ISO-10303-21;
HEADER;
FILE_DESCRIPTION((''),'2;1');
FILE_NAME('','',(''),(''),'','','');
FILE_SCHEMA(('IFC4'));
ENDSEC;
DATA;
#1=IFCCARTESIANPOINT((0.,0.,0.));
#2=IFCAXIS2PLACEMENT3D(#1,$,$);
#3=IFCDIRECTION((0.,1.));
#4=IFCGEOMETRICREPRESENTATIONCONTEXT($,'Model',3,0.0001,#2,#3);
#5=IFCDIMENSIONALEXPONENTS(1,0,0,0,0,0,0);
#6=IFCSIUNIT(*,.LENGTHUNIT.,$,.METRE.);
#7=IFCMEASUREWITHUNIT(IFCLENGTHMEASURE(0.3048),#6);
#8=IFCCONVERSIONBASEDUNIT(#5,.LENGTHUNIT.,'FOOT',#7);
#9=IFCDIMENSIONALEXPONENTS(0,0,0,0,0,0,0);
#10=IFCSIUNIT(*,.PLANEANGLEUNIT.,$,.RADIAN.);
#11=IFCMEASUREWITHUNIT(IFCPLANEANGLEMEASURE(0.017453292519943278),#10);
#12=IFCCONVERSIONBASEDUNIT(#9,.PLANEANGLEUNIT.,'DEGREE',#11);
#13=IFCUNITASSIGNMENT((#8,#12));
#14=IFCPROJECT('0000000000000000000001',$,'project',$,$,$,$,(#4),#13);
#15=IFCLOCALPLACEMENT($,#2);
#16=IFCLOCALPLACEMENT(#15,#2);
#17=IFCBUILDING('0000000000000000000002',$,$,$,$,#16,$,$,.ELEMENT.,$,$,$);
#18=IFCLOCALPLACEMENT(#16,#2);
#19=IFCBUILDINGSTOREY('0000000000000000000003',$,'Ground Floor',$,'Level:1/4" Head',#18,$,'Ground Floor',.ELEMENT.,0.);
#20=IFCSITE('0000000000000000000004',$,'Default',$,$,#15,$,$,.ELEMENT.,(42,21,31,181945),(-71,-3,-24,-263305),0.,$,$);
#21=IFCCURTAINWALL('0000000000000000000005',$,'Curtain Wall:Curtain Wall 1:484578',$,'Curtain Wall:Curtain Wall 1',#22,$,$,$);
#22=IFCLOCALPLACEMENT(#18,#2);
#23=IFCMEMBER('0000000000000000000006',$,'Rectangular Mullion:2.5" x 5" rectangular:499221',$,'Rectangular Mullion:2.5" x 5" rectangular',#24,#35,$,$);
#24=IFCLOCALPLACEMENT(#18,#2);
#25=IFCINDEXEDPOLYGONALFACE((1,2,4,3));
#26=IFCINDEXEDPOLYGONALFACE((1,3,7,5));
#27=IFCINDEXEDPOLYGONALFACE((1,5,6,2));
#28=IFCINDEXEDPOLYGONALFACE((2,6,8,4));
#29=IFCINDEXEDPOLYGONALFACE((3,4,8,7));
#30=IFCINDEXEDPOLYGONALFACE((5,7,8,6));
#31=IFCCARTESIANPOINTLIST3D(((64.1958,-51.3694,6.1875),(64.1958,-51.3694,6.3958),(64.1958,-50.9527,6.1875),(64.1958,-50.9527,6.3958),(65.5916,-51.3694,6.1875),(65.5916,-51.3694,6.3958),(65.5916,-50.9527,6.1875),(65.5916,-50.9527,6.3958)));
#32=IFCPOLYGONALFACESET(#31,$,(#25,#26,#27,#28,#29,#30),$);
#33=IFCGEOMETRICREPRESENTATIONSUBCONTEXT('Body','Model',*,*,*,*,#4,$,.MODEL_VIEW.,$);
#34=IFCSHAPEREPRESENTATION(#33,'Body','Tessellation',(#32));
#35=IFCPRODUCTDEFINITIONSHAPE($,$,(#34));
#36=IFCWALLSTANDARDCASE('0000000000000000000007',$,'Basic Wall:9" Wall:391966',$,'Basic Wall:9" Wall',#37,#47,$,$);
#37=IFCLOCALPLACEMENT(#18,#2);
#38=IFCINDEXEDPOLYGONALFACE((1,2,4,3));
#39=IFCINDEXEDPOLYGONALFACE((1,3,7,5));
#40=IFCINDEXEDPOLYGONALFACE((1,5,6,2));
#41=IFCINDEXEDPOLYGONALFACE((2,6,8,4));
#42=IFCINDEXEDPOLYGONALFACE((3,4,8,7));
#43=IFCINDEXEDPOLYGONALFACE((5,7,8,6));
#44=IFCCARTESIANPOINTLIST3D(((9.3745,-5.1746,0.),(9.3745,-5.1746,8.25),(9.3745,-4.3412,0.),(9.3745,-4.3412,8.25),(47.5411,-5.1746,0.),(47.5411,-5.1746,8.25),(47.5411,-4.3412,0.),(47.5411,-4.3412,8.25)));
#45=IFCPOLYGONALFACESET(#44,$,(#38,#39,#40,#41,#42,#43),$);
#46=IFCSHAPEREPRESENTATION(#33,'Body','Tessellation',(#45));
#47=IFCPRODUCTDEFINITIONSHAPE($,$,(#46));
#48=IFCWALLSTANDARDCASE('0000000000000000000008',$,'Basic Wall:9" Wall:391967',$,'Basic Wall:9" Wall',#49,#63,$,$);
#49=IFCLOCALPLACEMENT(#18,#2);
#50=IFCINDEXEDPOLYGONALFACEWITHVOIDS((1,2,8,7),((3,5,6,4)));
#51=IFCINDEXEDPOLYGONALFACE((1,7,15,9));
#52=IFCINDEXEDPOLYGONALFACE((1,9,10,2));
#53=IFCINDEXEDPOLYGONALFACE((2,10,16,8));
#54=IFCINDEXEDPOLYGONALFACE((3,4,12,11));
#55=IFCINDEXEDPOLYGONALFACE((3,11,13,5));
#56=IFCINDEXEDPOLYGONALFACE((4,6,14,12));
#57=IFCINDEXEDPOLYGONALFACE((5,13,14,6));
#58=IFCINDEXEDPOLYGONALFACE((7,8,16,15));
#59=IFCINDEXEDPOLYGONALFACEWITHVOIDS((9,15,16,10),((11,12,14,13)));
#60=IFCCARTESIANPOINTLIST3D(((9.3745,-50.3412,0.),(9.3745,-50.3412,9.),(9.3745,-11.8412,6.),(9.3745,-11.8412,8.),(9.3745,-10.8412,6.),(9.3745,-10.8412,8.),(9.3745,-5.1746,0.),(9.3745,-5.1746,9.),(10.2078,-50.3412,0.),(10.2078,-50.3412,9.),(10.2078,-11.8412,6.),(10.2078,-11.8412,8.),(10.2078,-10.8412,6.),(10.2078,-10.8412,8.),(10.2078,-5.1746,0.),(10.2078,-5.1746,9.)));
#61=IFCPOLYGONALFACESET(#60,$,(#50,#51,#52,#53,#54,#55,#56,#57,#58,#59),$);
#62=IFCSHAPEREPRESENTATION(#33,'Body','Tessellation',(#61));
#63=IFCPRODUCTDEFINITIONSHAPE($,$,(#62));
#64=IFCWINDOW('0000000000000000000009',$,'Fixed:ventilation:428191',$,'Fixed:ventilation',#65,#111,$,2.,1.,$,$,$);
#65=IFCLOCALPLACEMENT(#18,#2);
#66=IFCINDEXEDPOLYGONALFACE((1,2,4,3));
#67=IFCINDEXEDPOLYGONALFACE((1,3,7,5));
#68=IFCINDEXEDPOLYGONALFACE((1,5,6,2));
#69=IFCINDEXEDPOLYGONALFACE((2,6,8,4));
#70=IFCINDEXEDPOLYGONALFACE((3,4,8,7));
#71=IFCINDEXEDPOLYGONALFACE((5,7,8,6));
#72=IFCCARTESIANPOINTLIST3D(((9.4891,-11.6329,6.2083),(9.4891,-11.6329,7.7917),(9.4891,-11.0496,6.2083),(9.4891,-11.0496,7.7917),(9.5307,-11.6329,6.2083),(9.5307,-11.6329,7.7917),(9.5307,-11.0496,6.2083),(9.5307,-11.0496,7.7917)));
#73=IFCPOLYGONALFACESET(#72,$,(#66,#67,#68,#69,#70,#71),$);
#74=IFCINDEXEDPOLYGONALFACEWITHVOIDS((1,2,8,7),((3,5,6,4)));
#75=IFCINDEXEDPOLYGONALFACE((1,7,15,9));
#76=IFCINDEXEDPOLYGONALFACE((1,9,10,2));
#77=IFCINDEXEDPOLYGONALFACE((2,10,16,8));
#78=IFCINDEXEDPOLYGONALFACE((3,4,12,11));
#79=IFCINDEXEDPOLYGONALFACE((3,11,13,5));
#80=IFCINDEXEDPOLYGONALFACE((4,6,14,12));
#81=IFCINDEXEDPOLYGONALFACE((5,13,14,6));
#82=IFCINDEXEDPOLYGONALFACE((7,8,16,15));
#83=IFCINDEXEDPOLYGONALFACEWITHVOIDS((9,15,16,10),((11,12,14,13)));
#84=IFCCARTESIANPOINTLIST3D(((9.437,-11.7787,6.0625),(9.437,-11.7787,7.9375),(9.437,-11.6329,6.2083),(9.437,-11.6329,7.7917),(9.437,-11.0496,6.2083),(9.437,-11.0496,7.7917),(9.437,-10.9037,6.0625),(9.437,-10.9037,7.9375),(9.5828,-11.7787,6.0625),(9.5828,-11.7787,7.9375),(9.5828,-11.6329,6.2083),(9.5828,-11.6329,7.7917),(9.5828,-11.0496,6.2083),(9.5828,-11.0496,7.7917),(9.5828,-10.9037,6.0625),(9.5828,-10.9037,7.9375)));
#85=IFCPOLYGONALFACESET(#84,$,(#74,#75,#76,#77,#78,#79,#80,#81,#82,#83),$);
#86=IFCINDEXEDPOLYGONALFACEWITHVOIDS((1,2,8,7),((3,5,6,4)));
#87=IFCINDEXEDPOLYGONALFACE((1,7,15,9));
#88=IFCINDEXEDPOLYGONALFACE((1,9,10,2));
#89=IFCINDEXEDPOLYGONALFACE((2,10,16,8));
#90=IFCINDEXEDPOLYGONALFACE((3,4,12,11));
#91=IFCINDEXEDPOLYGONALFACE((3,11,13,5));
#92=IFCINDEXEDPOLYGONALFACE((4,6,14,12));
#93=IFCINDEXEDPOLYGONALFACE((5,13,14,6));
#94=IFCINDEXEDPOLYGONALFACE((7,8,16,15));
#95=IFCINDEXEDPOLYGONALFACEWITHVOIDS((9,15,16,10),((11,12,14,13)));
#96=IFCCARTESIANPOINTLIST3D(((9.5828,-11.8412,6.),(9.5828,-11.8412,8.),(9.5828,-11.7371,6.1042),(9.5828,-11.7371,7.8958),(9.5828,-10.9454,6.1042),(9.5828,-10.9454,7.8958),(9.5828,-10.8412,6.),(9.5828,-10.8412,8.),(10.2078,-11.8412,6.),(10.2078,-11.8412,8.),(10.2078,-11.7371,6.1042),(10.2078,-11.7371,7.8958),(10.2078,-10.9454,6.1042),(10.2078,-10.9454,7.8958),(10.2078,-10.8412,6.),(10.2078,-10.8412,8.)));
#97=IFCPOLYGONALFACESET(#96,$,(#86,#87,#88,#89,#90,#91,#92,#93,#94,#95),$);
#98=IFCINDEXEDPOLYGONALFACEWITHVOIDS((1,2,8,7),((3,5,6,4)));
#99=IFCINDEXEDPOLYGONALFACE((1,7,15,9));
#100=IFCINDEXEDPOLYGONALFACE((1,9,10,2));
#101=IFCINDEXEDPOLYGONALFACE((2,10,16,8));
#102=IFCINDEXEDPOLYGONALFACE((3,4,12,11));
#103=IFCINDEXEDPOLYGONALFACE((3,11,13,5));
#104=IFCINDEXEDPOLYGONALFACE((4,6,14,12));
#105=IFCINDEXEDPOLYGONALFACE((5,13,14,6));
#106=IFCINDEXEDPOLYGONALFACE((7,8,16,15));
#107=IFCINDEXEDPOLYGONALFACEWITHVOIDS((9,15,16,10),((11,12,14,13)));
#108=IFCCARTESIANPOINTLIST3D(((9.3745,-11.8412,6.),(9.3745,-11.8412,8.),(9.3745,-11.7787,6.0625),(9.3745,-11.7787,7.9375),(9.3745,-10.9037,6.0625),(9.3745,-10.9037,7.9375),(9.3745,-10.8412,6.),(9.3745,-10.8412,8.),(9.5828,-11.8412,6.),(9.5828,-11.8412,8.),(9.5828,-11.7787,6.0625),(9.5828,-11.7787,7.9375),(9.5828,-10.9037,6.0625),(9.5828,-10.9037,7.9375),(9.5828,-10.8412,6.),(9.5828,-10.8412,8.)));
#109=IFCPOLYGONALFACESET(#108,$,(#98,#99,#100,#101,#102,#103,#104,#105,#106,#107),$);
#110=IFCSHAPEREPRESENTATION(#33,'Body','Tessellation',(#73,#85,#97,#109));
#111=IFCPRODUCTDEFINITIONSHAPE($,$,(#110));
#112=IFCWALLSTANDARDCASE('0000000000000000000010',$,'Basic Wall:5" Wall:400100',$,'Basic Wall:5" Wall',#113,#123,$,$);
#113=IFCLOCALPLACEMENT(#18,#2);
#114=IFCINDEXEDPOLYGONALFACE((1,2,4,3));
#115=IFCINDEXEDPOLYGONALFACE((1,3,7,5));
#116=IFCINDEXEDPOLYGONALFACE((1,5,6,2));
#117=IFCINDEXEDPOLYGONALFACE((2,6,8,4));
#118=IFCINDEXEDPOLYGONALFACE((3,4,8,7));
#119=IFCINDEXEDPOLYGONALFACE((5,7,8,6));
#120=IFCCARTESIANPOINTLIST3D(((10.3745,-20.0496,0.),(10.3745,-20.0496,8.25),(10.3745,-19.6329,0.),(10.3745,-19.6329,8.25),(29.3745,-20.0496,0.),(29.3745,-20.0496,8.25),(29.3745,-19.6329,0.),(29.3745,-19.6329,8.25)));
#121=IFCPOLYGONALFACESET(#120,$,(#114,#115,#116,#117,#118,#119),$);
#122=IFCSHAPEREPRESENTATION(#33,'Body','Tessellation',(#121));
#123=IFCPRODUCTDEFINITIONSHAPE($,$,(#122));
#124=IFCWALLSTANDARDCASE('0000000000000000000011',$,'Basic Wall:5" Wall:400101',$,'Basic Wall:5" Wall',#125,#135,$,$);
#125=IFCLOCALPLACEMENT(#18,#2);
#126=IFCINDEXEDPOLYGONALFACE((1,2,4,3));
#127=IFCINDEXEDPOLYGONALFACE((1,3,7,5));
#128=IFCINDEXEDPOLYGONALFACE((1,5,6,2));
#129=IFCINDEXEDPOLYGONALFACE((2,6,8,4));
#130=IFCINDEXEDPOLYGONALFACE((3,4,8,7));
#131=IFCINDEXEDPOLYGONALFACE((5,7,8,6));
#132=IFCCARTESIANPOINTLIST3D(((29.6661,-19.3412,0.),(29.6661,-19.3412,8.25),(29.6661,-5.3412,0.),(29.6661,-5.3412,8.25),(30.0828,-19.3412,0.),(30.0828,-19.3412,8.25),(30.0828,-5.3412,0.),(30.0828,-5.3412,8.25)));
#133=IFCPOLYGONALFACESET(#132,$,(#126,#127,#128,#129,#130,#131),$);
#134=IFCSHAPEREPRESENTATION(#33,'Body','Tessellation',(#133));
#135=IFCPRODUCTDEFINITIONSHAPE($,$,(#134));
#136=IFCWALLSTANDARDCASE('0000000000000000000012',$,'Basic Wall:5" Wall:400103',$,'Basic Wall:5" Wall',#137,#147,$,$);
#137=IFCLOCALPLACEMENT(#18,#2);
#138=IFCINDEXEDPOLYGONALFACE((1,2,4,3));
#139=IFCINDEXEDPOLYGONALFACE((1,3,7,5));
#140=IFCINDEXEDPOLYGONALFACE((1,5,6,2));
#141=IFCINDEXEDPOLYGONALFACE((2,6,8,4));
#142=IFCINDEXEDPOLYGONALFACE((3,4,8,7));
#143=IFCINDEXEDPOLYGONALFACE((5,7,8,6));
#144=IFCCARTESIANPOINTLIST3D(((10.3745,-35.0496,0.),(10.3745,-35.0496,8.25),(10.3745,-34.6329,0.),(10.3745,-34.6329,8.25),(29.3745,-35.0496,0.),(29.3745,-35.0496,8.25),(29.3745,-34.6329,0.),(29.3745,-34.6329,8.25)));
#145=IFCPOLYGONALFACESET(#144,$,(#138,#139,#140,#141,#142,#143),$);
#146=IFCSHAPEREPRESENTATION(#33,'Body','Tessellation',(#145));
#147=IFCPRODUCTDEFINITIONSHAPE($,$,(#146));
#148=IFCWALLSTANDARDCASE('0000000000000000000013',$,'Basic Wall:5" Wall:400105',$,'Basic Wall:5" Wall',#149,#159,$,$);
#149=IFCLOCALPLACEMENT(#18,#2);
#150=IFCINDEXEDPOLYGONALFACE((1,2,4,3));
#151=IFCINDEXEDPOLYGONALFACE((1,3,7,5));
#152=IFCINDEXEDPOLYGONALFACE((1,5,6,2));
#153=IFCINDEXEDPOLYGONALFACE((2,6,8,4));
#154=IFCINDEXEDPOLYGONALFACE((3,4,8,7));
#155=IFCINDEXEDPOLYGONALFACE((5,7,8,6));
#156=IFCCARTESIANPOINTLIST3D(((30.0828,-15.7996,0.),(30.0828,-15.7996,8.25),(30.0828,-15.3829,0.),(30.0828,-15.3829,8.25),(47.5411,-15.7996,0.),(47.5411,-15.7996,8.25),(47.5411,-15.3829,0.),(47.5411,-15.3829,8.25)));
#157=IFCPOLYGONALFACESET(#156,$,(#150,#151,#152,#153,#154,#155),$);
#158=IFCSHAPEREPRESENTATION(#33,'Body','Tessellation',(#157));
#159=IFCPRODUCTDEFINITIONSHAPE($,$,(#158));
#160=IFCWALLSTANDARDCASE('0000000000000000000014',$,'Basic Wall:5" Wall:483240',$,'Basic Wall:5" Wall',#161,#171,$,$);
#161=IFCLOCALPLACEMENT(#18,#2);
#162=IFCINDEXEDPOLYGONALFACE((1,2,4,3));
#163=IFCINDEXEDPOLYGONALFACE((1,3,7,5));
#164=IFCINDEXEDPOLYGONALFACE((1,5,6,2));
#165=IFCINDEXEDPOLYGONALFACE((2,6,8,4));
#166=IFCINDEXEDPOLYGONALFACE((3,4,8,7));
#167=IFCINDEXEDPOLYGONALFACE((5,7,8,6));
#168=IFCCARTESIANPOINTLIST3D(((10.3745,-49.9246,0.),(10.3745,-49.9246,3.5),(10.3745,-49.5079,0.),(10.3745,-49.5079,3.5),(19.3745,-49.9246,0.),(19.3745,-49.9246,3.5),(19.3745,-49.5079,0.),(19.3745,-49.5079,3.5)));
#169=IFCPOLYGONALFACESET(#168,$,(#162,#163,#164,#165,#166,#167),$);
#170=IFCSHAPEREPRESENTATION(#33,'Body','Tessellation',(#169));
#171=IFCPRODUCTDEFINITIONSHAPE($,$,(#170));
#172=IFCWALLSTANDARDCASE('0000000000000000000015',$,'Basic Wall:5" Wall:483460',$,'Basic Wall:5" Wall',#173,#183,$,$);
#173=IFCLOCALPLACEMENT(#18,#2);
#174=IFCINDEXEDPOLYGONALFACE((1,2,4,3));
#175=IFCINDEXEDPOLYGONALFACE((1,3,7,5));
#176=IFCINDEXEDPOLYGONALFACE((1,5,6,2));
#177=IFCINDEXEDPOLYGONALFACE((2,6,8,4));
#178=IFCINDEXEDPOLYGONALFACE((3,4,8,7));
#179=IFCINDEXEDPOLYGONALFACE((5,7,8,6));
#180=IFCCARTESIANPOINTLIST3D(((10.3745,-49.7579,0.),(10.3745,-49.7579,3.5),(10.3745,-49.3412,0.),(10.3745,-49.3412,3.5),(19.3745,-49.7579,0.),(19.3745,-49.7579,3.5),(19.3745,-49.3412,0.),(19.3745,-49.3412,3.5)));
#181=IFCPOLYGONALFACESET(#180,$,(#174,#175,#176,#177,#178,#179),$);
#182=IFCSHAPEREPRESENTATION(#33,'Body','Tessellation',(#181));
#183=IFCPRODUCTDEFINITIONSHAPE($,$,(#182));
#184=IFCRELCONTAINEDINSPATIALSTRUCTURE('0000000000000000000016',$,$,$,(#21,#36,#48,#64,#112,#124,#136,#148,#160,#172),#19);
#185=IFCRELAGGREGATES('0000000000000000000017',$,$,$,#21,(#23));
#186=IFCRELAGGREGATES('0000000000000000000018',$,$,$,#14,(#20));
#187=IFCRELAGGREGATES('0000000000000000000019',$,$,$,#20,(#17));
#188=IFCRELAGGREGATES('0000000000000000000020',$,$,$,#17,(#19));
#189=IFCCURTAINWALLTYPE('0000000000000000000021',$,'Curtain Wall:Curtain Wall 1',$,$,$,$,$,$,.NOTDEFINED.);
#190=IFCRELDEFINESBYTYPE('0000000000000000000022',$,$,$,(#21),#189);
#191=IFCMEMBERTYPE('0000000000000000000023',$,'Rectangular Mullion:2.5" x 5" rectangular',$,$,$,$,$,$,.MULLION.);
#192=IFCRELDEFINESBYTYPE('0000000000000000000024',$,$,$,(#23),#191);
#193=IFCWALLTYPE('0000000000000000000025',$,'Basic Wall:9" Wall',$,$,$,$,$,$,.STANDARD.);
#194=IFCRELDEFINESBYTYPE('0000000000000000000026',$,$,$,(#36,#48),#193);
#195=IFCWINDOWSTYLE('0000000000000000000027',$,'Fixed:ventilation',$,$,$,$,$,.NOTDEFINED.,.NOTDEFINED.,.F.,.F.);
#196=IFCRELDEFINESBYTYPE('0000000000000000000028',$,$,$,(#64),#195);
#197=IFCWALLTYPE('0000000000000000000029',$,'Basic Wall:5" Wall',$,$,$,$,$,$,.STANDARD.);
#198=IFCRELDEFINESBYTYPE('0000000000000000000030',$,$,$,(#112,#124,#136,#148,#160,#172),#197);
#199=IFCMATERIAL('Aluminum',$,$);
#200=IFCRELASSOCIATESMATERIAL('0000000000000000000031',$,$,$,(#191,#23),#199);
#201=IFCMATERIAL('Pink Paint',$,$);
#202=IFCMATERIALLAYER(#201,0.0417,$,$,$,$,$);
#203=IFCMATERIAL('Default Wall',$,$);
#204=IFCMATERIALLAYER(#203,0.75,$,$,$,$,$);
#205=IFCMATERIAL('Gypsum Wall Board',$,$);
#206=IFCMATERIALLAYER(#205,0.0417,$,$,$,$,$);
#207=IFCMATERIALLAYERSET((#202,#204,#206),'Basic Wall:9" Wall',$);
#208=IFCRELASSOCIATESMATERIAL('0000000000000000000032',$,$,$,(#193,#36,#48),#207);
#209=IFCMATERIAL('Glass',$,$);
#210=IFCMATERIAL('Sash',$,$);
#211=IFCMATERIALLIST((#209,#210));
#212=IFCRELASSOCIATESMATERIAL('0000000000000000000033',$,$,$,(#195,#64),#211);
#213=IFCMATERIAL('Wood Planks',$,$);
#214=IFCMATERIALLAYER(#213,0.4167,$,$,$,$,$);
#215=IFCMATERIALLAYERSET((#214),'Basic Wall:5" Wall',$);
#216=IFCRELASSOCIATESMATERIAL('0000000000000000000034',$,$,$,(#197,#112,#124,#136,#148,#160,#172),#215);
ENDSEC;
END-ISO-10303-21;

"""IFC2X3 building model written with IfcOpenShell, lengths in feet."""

from ifc_helpers import new_model, entity, si_unit, converted_unit, direction, frame, frame_2d, origin, origin_2d_with_axis, place, context, subcontext, project, spatial, polyline, rectangle, outline, extrude, source, transform, mapped, material, material_list, layer, layer_set, layer_usage, type_object, type_shapes, element, fill, aggregate, save


model = new_model("IFC2X3")

# Units and contexts
model_context = context("Model", 3, precision=0.0001, world=origin(), true_north=direction((0.0, 1.0)))
body_context = subcontext(model_context, "Body", "Model", "MODEL_VIEW")
ifc_project = project(units=[converted_unit("LENGTHUNIT", "FOOT", entity("IfcLengthMeasure", 0.3048), si_unit("LENGTHUNIT", "METRE"), dimensions=[1, 0, 0, 0, 0, 0, 0]), converted_unit("PLANEANGLEUNIT", "DEGREE", entity("IfcPlaneAngleMeasure", 0.017453292519943278), si_unit("PLANEANGLEUNIT", "RADIAN"), dimensions=[0, 0, 0, 0, 0, 0, 0])], contexts=[model_context])

# Site, building, storey
site_placement = place(None, origin())
site = spatial("IfcSite", under=ifc_project, at=site_placement, Name="Default", CompositionType="ELEMENT", RefLatitude=(42, 21, 31, 181945), RefLongitude=(-71, -3, -24, -263305), RefElevation=0.0)
building_placement = place(site_placement, origin())
building = spatial("IfcBuilding", under=site, at=building_placement, CompositionType="ELEMENT")
storey_placement = place(building_placement, origin())
storey = spatial("IfcBuildingStorey", under=building, at=storey_placement, Name="Ground Floor", ObjectType="Level:1/4\" Head", LongName="Ground Floor", CompositionType="ELEMENT", Elevation=0.0)

# Curtain wall, member
curtain_wall_type = type_object("IfcCurtainWallType", Name="Curtain Wall:Curtain Wall 1", PredefinedType="NOTDEFINED")
curtain_wall_placement = place(storey_placement, origin())
curtain_wall = element("IfcCurtainWall", 1, at=curtain_wall_placement, inside=storey, type_object=curtain_wall_type, Name="Curtain Wall:Curtain Wall 1:484578", ObjectType="Curtain Wall:Curtain Wall 1")
ifc_material_1 = material(Name="Aluminum")
member_type_1 = type_object("IfcMemberType", Name="Rectangular Mullion:2.5\" x 5\" rectangular", PredefinedType="MULLION", material=ifc_material_1)
shared_shape_1 = source(origin(), body_context, "Body", "SweptSolid", [
    extrude(rectangle(XDim=0.2083, YDim=0.4167, at=origin_2d_with_axis()), frame((0.0, 0.0, -1.3958), z_axis=(0.0, 0.0, 1.0), x_axis=(-1.0, 0.0, 0.0)), (0.0, 0.0, 1.0), 1.3958),
])
type_shapes(member_type_1, [shared_shape_1])
member_1_placement = place(curtain_wall_placement, frame((65.5916, -51.161, 6.2917), z_axis=(1.0, 0.0, 0.0), x_axis=(0.0, 0.0, 1.0)))
member_1 = element("IfcMember", 2, at=member_1_placement, type_object=member_type_1, material=ifc_material_1, Name="Rectangular Mullion:2.5\" x 5\" rectangular:499221", ObjectType="Rectangular Mullion:2.5\" x 5\" rectangular", context=body_context, shape_type="MappedRepresentation", body=[
    mapped(shared_shape_1, transform((0.0, 0.0, 0.0), scale=1.0)),
])

# Shared definitions
ifc_material_2 = material(Name="Glass")
aggregate(curtain_wall, [member_1])

# Wall
ifc_material_3 = material(Name="Pink Paint")
ifc_layer_1 = layer(ifc_material_3, 0.0417)
ifc_material_4 = material(Name="Default Wall")
ifc_layer_2 = layer(ifc_material_4, 0.75)
ifc_material_5 = material(Name="Gypsum Wall Board")
ifc_layer_3 = layer(ifc_material_5, 0.0417)
ifc_layer_set_1 = layer_set([ifc_layer_1, ifc_layer_2, ifc_layer_3], Name="Basic Wall:9\" Wall")
ifc_layer_usage_1 = layer_usage(ifc_layer_set_1, "AXIS2", "NEGATIVE", 0.4167)
wall_type_1 = type_object("IfcWallType", Name="Basic Wall:9\" Wall", PredefinedType="STANDARD", material=ifc_layer_set_1)
wall_1_placement = place(storey_placement, frame((9.3745, -4.7579, 0.0)))
element("IfcWallStandardCase", 3, at=wall_1_placement, inside=storey, type_object=wall_type_1, material=ifc_layer_usage_1, Name="Basic Wall:9\" Wall:391966", ObjectType="Basic Wall:9\" Wall", context=body_context, shape_type="SweptSolid", body=[
    extrude(rectangle(XDim=38.1667, YDim=0.8333, at=frame_2d((19.0833, 0.0), x_axis=(-1.0, 0.0))), origin(), (0.0, 0.0, 1.0), 8.25),
])

# Wall, opening, window
wall_2_placement = place(storey_placement, frame((9.7911, -50.3412, 0.0), z_axis=(0.0, 0.0, 1.0), x_axis=(0.0, 1.0, 0.0)))
wall_2 = element("IfcWallStandardCase", 4, at=wall_2_placement, inside=storey, type_object=wall_type_1, material=ifc_layer_usage_1, Name="Basic Wall:9\" Wall:391967", ObjectType="Basic Wall:9\" Wall", context=body_context, shape_type="SweptSolid", body=[
    extrude(rectangle(XDim=45.1667, YDim=0.8333, at=frame_2d((22.5833, 0.0), x_axis=(-1.0, 0.0))), origin(), (0.0, 0.0, 1.0), 9.0),
])
opening_1_placement = place(wall_2_placement, frame((38.5, -0.4167, 6.0)))
opening_1 = element("IfcOpeningElement", 5, at=opening_1_placement, cuts=wall_2, ObjectType="Opening", context=body_context, shape_type="SweptSolid", body=[
    extrude(rectangle(XDim=2.0, YDim=1.0, at=frame_2d((1.0, 0.5), x_axis=(-1.0, 0.0))), frame((0.0, 0.0, 0.0), z_axis=(0.0, 1.0, 0.0), x_axis=(0.0, 0.0, 1.0)), (0.0, 0.0, 1.0), 0.8333),
])
ifc_material_6 = material(Name="Sash")
ifc_material_list_1 = material_list([ifc_material_2, ifc_material_6])
window_style = type_object("IfcWindowStyle", Name="Fixed:ventilation", ConstructionType="NOTDEFINED", OperationType="NOTDEFINED", ParameterTakesPrecedence=False, Sizeable=False, material=ifc_material_list_1)
shared_shape_2 = source(origin(), body_context, "Body", "SweptSolid", [
    extrude(rectangle(XDim=0.0417, YDim=0.5833, at=origin_2d_with_axis()), frame((0.5, 0.6979, 0.2083), z_axis=(0.0, 0.0, 1.0), x_axis=(0.0, 1.0, 0.0)), (0.0, 0.0, 1.0), 1.5833),
    extrude(outline(polyline([(-0.4375, -0.9375), (0.4375, -0.9375), (0.4375, 0.9375), (-0.4375, 0.9375), (-0.4375, -0.9375)]), holes=[polyline([(-0.2917, -0.7917), (-0.2917, 0.7917), (0.2917, 0.7917), (0.2917, -0.7917), (-0.2917, -0.7917)])]), frame((0.5, 0.625, 1.0), z_axis=(0.0, 1.0, 0.0), x_axis=(1.0, 0.0, 0.0)), (0.0, 0.0, 1.0), 0.1458),
    extrude(outline(polyline([(-0.5, -1.0), (0.5, -1.0), (0.5, 1.0), (-0.5, 1.0), (-0.5, -1.0)]), holes=[polyline([(-0.3958, -0.8958), (-0.3958, 0.8958), (0.3958, 0.8958), (0.3958, -0.8958), (-0.3958, -0.8958)])]), frame((0.5, 0.0, 1.0), z_axis=(0.0, 1.0, 0.0), x_axis=(1.0, 0.0, 0.0)), (0.0, 0.0, 1.0), 0.625),
    extrude(outline(polyline([(-1.0, -0.5), (1.0, -0.5), (1.0, 0.5), (-1.0, 0.5), (-1.0, -0.5)]), holes=[polyline([(-0.9375, -0.4375), (-0.9375, 0.4375), (0.9375, 0.4375), (0.9375, -0.4375), (-0.9375, -0.4375)])]), frame((0.5, 0.625, 1.0), z_axis=(0.0, 1.0, 0.0), x_axis=(0.0, 0.0, -1.0)), (0.0, 0.0, 1.0), 0.2083),
])
type_shapes(window_style, [shared_shape_2])
window_placement = place(opening_1_placement, origin())
window = element("IfcWindow", 6, at=window_placement, inside=storey, type_object=window_style, material=ifc_material_list_1, Name="Fixed:ventilation:428191", ObjectType="Fixed:ventilation", OverallHeight=2.0, OverallWidth=1.0, context=body_context, shape_type="MappedRepresentation", body=[
    mapped(shared_shape_2, transform((0.0, 0.0, 0.0), scale=1.0)),
])
fill(opening_1, window)

# Walls
ifc_material_7 = material(Name="Wood Planks")
ifc_layer_4 = layer(ifc_material_7, 0.4167)
ifc_layer_set_2 = layer_set([ifc_layer_4], Name="Basic Wall:5\" Wall")
ifc_layer_usage_2 = layer_usage(ifc_layer_set_2, "AXIS2", "NEGATIVE", 0.2083)
wall_type_2 = type_object("IfcWallType", Name="Basic Wall:5\" Wall", PredefinedType="STANDARD", material=ifc_layer_set_2)
wall_3_placement = place(storey_placement, frame((10.3745, -19.8412, 0.0)))
element("IfcWallStandardCase", 7, at=wall_3_placement, inside=storey, type_object=wall_type_2, material=ifc_layer_usage_2, Name="Basic Wall:5\" Wall:400100", ObjectType="Basic Wall:5\" Wall", context=body_context, shape_type="SweptSolid", body=[
    extrude(rectangle(XDim=19.0, YDim=0.4167, at=frame_2d((9.5, 0.0), x_axis=(-1.0, 0.0))), origin(), (0.0, 0.0, 1.0), 8.25),
])
wall_4_placement = place(storey_placement, frame((29.8745, -19.3412, 0.0), z_axis=(0.0, 0.0, 1.0), x_axis=(0.0, 1.0, 0.0)))
element("IfcWallStandardCase", 8, at=wall_4_placement, inside=storey, type_object=wall_type_2, material=ifc_layer_usage_2, Name="Basic Wall:5\" Wall:400101", ObjectType="Basic Wall:5\" Wall", context=body_context, shape_type="SweptSolid", body=[
    extrude(rectangle(XDim=14.0, YDim=0.4167, at=frame_2d((7.0, 0.0), x_axis=(-1.0, 0.0))), origin(), (0.0, 0.0, 1.0), 8.25),
])

# Wall
wall_5_placement = place(storey_placement, frame((29.3745, -34.8412, 0.0), z_axis=(0.0, 0.0, 1.0), x_axis=(-1.0, 0.0, 0.0)))
element("IfcWallStandardCase", 9, at=wall_5_placement, inside=storey, type_object=wall_type_2, material=ifc_layer_usage_2, Name="Basic Wall:5\" Wall:400103", ObjectType="Basic Wall:5\" Wall", context=body_context, shape_type="SweptSolid", body=[
    extrude(rectangle(XDim=19.0, YDim=0.4167, at=frame_2d((9.5, 0.0), x_axis=(-1.0, 0.0))), origin(), (0.0, 0.0, 1.0), 8.25),
])

# Walls
wall_6_placement = place(storey_placement, frame((30.0828, -15.5912, 0.0)))
element("IfcWallStandardCase", 10, at=wall_6_placement, inside=storey, type_object=wall_type_2, material=ifc_layer_usage_2, Name="Basic Wall:5\" Wall:400105", ObjectType="Basic Wall:5\" Wall", context=body_context, shape_type="SweptSolid", body=[
    extrude(rectangle(XDim=17.4583, YDim=0.4167, at=frame_2d((8.7292, 0.0), x_axis=(-1.0, 0.0))), origin(), (0.0, 0.0, 1.0), 8.25),
])
wall_7_placement = place(storey_placement, frame((10.3745, -49.7162, 0.0)))
element("IfcWallStandardCase", 11, at=wall_7_placement, inside=storey, type_object=wall_type_2, material=ifc_layer_usage_2, Name="Basic Wall:5\" Wall:483240", ObjectType="Basic Wall:5\" Wall", context=body_context, shape_type="SweptSolid", body=[
    extrude(rectangle(XDim=9.0, YDim=0.4167, at=frame_2d((4.5, 0.0), x_axis=(-1.0, 0.0))), origin(), (0.0, 0.0, 1.0), 3.5),
])
wall_8_placement = place(storey_placement, frame((10.3745, -49.5496, 0.0)))
element("IfcWallStandardCase", 12, at=wall_8_placement, inside=storey, type_object=wall_type_2, material=ifc_layer_usage_2, Name="Basic Wall:5\" Wall:483460", ObjectType="Basic Wall:5\" Wall", context=body_context, shape_type="SweptSolid", body=[
    extrude(rectangle(XDim=9.0, YDim=0.4167, at=frame_2d((4.5, 0.0), x_axis=(-1.0, 0.0))), origin(), (0.0, 0.0, 1.0), 3.5),
])

save(model, "model.ifc")
